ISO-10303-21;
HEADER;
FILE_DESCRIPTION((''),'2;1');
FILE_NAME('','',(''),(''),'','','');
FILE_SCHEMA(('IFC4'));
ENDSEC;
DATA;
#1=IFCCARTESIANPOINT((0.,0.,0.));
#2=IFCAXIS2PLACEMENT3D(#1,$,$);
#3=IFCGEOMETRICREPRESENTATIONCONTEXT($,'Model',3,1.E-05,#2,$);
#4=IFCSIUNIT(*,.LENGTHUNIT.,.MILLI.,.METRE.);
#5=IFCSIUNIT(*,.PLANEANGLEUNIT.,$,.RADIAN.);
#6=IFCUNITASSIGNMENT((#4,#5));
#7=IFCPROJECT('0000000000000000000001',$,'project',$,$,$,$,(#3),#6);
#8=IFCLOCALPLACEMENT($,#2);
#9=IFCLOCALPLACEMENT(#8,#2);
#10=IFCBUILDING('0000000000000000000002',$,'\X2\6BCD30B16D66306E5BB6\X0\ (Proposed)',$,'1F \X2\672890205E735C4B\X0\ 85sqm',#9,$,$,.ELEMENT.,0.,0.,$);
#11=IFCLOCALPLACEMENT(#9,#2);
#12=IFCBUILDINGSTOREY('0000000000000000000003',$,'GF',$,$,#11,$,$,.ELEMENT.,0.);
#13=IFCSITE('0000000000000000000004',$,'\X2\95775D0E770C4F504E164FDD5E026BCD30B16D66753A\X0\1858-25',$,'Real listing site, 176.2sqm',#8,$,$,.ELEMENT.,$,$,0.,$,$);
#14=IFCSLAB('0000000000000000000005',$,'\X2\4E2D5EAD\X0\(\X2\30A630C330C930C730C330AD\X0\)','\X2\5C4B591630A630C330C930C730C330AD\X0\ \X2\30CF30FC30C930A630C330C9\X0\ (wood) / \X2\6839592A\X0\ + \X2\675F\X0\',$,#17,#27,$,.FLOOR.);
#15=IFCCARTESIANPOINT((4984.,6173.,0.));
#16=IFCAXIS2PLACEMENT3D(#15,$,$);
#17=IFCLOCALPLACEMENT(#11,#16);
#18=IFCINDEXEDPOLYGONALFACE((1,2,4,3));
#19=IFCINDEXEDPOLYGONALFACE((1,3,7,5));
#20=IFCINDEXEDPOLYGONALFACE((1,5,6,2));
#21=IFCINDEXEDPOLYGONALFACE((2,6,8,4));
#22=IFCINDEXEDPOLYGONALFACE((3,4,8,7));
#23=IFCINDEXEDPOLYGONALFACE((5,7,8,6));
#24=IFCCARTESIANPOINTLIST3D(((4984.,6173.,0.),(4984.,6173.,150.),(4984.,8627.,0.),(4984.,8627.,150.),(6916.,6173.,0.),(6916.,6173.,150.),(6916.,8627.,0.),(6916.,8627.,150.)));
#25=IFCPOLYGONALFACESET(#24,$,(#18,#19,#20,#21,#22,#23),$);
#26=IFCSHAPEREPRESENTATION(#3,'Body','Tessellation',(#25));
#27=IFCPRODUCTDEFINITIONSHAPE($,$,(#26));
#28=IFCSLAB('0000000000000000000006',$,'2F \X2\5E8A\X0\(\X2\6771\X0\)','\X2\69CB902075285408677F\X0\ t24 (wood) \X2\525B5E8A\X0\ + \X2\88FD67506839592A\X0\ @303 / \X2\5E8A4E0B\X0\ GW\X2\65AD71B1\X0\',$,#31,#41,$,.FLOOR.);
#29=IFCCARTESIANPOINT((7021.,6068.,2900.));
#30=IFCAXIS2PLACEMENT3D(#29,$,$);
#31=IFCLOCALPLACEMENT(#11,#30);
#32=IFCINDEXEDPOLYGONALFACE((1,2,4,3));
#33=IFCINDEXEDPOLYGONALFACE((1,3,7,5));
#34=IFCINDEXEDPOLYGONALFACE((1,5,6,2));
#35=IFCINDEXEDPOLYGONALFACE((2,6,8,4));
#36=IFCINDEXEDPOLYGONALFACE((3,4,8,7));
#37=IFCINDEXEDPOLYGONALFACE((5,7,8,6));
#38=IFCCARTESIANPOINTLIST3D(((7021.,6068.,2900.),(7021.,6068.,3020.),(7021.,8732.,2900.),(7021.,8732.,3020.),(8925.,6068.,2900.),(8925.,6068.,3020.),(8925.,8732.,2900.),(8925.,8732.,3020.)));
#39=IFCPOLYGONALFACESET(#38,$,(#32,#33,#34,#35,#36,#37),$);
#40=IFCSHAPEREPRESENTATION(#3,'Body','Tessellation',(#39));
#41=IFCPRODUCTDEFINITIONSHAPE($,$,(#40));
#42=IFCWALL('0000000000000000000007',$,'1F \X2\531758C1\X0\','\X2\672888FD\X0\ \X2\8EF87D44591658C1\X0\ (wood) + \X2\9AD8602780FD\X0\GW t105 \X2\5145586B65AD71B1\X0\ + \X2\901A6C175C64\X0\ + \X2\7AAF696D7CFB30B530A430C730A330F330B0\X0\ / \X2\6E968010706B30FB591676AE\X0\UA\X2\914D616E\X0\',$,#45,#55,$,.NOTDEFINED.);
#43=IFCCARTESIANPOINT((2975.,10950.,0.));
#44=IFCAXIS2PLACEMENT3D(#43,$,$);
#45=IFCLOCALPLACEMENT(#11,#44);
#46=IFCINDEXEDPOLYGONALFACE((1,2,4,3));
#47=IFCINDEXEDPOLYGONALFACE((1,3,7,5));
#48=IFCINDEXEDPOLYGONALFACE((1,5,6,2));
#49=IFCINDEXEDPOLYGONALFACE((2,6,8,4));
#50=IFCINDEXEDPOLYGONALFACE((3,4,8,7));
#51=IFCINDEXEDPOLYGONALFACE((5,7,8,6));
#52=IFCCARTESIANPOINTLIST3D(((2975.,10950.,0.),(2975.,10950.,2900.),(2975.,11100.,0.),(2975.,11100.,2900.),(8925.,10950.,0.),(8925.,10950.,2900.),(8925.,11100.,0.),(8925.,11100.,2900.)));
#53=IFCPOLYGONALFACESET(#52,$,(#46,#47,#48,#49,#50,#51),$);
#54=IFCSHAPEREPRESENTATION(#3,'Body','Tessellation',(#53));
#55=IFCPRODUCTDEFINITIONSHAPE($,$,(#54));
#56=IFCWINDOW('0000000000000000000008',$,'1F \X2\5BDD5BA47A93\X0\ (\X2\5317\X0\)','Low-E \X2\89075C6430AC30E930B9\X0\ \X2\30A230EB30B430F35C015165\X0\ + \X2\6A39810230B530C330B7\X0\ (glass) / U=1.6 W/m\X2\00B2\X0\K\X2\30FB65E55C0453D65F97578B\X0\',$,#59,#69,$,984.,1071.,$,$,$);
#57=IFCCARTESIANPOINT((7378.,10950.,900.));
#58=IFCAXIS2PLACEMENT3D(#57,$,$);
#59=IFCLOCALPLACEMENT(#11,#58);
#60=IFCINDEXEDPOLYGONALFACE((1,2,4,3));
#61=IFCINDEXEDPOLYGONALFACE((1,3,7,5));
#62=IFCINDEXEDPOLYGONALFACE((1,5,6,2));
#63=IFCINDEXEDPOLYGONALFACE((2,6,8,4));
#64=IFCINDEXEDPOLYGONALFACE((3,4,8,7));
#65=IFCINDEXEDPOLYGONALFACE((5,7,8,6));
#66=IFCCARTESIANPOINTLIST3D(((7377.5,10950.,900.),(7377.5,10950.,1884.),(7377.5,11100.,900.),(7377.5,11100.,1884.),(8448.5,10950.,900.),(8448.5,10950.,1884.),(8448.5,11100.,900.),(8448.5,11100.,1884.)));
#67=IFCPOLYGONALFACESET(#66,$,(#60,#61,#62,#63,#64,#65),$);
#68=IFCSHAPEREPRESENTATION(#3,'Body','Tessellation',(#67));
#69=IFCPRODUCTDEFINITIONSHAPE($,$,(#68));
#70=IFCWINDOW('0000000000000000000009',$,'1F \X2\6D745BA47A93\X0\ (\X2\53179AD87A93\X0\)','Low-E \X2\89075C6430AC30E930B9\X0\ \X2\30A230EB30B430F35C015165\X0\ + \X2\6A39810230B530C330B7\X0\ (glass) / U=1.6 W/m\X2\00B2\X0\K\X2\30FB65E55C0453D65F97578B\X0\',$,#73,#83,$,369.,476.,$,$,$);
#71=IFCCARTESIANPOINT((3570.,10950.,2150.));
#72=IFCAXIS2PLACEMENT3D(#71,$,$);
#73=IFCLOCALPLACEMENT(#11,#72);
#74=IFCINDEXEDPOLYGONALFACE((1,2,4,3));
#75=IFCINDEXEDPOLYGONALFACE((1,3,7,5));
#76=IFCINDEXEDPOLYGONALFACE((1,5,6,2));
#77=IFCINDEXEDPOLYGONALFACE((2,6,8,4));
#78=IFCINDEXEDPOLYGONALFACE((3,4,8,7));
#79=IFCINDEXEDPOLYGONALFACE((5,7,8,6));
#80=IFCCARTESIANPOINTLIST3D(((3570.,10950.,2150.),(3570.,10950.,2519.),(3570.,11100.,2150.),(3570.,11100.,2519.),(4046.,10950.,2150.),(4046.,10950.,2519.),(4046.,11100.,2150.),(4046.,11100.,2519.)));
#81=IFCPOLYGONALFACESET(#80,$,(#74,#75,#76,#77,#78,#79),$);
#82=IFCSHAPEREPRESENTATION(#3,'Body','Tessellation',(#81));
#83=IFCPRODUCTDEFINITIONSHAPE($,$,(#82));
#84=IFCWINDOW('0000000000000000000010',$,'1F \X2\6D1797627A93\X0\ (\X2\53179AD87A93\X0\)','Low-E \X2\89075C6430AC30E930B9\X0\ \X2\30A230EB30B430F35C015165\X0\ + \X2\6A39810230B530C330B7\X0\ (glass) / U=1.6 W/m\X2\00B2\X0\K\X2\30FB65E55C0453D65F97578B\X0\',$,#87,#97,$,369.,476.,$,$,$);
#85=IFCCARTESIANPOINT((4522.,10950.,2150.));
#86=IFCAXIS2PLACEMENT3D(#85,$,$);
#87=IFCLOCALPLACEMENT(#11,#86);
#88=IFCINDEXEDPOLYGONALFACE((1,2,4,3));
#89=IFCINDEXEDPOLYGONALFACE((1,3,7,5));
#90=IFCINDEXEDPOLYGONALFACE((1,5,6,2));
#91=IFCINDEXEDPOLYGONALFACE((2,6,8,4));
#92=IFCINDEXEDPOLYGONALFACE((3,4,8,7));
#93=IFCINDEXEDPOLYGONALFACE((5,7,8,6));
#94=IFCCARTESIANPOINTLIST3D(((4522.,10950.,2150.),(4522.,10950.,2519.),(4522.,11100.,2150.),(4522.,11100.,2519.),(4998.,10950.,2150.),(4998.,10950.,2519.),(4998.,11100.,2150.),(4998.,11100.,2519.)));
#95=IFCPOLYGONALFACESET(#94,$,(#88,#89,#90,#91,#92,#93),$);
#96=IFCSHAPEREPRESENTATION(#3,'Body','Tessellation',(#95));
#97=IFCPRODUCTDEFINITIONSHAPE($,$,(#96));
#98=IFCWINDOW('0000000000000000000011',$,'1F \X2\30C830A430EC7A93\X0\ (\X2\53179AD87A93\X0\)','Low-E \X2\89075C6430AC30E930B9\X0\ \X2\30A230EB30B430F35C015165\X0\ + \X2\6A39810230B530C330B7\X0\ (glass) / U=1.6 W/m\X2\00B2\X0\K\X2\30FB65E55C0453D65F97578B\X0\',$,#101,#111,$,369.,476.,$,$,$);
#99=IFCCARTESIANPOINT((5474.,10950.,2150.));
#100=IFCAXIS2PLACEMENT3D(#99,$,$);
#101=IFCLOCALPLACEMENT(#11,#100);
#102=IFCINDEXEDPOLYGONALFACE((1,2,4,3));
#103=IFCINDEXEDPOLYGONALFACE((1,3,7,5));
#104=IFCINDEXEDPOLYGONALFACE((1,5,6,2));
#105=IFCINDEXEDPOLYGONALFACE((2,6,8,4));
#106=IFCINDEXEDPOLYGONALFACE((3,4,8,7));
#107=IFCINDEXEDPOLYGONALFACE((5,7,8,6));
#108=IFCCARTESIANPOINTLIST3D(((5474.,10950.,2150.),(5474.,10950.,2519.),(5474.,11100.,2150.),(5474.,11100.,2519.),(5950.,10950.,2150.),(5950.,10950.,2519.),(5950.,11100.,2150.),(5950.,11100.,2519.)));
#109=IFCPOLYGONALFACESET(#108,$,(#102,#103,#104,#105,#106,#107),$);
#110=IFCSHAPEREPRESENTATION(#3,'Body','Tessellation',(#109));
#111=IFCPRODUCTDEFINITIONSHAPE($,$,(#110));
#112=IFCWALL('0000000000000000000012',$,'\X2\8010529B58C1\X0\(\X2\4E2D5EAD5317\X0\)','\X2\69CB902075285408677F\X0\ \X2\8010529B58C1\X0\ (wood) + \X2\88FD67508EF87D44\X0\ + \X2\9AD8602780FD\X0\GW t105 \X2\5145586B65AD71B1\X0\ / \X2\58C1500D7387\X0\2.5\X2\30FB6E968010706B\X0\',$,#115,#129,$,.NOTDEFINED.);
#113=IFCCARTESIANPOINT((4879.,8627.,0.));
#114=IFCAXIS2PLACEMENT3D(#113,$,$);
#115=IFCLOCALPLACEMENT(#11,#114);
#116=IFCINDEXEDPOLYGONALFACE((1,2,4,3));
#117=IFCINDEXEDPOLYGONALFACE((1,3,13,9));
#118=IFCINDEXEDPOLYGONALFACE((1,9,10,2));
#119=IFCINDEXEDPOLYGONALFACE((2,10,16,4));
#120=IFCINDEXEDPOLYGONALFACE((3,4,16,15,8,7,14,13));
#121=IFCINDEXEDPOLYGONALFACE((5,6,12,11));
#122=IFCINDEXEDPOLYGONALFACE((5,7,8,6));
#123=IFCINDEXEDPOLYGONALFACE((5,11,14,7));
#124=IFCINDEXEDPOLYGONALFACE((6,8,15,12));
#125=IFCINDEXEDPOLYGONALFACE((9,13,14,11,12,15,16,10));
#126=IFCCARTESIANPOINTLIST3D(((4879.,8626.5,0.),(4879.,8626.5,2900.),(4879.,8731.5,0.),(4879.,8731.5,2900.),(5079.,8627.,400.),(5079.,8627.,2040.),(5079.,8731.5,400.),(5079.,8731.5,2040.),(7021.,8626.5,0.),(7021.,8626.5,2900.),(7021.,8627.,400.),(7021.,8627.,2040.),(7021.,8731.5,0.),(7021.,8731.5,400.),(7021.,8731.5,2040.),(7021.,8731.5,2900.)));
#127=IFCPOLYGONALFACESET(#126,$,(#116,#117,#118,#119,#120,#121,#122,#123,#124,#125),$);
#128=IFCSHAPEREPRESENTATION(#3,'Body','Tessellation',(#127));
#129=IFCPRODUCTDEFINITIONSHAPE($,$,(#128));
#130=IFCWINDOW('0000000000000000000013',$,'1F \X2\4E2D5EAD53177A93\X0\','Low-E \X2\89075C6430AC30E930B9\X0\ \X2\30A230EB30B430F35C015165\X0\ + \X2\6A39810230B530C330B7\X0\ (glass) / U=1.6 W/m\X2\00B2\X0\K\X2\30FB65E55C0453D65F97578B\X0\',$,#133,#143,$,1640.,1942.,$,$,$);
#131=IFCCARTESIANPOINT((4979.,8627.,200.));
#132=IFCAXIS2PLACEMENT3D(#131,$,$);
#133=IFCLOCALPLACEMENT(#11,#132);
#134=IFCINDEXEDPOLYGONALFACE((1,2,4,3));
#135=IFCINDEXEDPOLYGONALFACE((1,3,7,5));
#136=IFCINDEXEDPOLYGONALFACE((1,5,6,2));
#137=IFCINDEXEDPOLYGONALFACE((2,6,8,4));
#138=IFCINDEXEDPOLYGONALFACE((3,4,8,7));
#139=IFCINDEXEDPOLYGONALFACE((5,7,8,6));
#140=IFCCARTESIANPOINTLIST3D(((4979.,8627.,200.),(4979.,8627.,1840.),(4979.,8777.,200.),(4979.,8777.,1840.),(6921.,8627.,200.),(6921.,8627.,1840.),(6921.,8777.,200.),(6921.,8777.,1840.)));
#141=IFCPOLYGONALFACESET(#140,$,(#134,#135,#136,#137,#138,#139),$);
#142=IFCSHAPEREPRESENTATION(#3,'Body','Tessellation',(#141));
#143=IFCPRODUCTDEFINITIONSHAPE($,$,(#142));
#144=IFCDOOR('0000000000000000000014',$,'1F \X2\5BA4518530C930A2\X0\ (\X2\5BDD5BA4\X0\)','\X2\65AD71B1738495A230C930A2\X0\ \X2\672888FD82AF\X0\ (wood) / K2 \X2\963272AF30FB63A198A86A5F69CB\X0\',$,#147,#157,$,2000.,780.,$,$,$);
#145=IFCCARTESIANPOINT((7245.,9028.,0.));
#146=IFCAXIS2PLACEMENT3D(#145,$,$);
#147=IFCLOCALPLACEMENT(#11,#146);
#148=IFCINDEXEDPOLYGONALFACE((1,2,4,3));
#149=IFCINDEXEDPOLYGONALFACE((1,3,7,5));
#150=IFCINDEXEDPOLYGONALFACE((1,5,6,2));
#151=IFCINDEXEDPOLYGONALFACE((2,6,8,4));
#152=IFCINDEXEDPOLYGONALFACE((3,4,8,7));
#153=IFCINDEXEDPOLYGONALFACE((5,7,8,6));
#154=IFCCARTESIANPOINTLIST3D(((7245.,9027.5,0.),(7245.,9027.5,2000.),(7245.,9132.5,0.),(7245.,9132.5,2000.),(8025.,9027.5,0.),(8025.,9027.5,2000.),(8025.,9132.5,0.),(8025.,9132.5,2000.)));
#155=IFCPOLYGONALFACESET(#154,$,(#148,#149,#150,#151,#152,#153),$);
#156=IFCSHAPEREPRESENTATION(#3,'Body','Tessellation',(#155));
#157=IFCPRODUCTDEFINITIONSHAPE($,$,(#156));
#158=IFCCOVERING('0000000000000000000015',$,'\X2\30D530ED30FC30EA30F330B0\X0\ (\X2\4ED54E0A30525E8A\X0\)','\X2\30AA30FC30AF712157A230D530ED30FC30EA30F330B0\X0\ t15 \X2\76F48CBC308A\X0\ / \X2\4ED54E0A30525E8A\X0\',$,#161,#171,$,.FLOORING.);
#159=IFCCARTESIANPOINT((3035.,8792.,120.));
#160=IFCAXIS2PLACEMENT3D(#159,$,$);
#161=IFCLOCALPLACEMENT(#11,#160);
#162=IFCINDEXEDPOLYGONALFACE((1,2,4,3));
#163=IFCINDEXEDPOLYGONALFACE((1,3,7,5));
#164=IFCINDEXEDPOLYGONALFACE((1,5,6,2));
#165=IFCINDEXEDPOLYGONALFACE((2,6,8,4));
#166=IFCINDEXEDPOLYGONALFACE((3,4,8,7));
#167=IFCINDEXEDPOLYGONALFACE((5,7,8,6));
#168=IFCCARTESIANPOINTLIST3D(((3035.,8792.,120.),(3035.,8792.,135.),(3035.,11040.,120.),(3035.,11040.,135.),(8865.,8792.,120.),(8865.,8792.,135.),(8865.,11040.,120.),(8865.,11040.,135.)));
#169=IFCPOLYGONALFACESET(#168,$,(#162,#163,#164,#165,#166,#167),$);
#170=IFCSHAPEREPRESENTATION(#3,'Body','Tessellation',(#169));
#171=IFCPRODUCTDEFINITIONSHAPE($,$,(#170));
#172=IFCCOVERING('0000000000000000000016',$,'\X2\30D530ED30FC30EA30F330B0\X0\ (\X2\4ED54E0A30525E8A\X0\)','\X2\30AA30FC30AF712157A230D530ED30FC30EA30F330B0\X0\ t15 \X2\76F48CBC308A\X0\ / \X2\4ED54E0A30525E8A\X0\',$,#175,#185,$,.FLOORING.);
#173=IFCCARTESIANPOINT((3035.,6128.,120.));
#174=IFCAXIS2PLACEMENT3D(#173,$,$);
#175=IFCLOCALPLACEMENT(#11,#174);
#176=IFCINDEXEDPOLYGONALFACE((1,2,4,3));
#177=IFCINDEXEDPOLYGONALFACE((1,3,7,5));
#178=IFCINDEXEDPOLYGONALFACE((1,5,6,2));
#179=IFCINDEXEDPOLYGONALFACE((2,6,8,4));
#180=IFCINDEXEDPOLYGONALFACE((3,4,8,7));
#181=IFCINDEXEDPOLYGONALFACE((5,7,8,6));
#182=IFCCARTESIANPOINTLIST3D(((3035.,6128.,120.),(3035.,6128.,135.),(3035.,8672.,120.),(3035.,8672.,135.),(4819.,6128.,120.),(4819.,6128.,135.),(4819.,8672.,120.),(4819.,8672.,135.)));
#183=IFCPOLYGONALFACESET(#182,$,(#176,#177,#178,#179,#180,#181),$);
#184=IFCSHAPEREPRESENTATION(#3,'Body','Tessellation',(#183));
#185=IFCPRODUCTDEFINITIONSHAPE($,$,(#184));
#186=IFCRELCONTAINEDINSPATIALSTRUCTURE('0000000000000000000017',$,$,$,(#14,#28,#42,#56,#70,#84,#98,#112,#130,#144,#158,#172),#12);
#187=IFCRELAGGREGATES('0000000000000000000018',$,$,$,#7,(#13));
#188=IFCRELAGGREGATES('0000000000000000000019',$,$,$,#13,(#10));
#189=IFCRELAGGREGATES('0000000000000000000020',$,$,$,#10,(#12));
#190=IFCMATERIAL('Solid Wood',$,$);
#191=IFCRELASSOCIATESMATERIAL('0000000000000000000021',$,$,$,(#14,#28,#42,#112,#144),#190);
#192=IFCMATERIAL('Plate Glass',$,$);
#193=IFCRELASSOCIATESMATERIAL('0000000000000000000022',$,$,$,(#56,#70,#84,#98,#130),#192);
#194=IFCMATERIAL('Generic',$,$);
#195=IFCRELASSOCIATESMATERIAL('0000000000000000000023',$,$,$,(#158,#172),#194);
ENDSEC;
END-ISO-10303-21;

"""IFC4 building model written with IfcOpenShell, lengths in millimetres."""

from ifc_helpers import new_model, si_unit, frame, frame_2d, origin, place, context, project, spatial, rectangle, extrude, material, element, fill, save


model = new_model("IFC4")

# Units and contexts
model_context = context("Model", 3, precision=1e-05, world=origin())
ifc_project = project(units=[si_unit("LENGTHUNIT", "METRE", prefix="MILLI"), si_unit("PLANEANGLEUNIT", "RADIAN")], contexts=[model_context])

# Site, building, storey
site_placement = place(None, origin())
site = spatial("IfcSite", under=ifc_project, at=site_placement, Name="長崎県佐世保市母ケ浦町1858-25", ObjectType="Real listing site, 176.2sqm", CompositionType="ELEMENT", RefElevation=0.0)
building_placement = place(site_placement, origin())
building = spatial("IfcBuilding", under=site, at=building_placement, Name="母ケ浦の家 (Proposed)", ObjectType="1F 木造平屋 85sqm", CompositionType="ELEMENT", ElevationOfRefHeight=0.0, ElevationOfTerrain=0.0)
storey_placement = place(building_placement, origin())
storey = spatial("IfcBuildingStorey", under=building, at=storey_placement, Name="GF", CompositionType="ELEMENT", Elevation=0.0)

# Slabs
ifc_material_1 = material(Name="Solid Wood")
slab_1_placement = place(storey_placement, frame((4984.0, 6173.0, 0.0)))
element("IfcSlab", 1, at=slab_1_placement, inside=storey, material=ifc_material_1, Name="中庭(ウッドデッキ)", Description="屋外ウッドデッキ ハードウッド (wood) / 根太 + 束", PredefinedType="FLOOR", context=model_context, shape_type="SweptSolid", body=[
    extrude(rectangle(XDim=1932.0, YDim=2454.0, at=frame_2d((966.0, 1227.0))), frame((4984.0, 6173.0, 0.0)), (0.0, 0.0, 1.0), 150.0),
])
slab_2_placement = place(storey_placement, frame((7021.0, 6068.0, 2900.0)))
element("IfcSlab", 2, at=slab_2_placement, inside=storey, material=ifc_material_1, Name="2F 床(東)", Description="構造用合板 t24 (wood) 剛床 + 製材根太 @303 / 床下 GW断熱", PredefinedType="FLOOR", context=model_context, shape_type="SweptSolid", body=[
    extrude(rectangle(XDim=1904.0, YDim=2664.0, at=frame_2d((952.0, 1332.0))), frame((7021.0, 6068.0, 2900.0)), (0.0, 0.0, 1.0), 120.0),
])

# Wall, openings, windows
wall_1_placement = place(storey_placement, frame((2975.0, 10950.0, 0.0)))
wall_1 = element("IfcWall", 3, at=wall_1_placement, inside=storey, material=ifc_material_1, Name="1F 北壁", Description="木製 軸組外壁 (wood) + 高性能GW t105 充填断熱 + 通気層 + 窯業系サイディング / 準耐火・外皮UA配慮", PredefinedType="NOTDEFINED", context=model_context, shape_type="SweptSolid", body=[
    extrude(rectangle(XDim=5950.0, YDim=150.0, at=frame_2d((2975.0, 75.0))), frame((2975.0, 10950.0, 0.0)), (0.0, 0.0, 1.0), 2900.0),
])
opening_1_placement = place(storey_placement, frame((7378.0, 10950.0, 900.0)))
opening_1 = element("IfcOpeningElement", 4, at=opening_1_placement, cuts=wall_1, PredefinedType="NOTDEFINED", context=model_context, shape_type="SweptSolid", body=[
    extrude(rectangle(XDim=1071.0, YDim=150.0, at=frame_2d((535.0, 75.0))), frame((7378.0, 10950.0, 900.0)), (0.0, 0.0, 1.0), 984.0),
])
opening_2_placement = place(storey_placement, frame((3570.0, 10950.0, 2150.0)))
opening_2 = element("IfcOpeningElement", 5, at=opening_2_placement, cuts=wall_1, PredefinedType="NOTDEFINED", context=model_context, shape_type="SweptSolid", body=[
    extrude(rectangle(XDim=476.0, YDim=150.0, at=frame_2d((238.0, 75.0))), frame((3570.0, 10950.0, 2150.0)), (0.0, 0.0, 1.0), 369.0),
])
opening_3_placement = place(storey_placement, frame((4522.0, 10950.0, 2150.0)))
opening_3 = element("IfcOpeningElement", 6, at=opening_3_placement, cuts=wall_1, PredefinedType="NOTDEFINED", context=model_context, shape_type="SweptSolid", body=[
    extrude(rectangle(XDim=476.0, YDim=150.0, at=frame_2d((238.0, 75.0))), frame((4522.0, 10950.0, 2150.0)), (0.0, 0.0, 1.0), 369.0),
])
opening_4_placement = place(storey_placement, frame((5474.0, 10950.0, 2150.0)))
opening_4 = element("IfcOpeningElement", 7, at=opening_4_placement, cuts=wall_1, PredefinedType="NOTDEFINED", context=model_context, shape_type="SweptSolid", body=[
    extrude(rectangle(XDim=476.0, YDim=150.0, at=frame_2d((238.0, 75.0))), frame((5474.0, 10950.0, 2150.0)), (0.0, 0.0, 1.0), 369.0),
])
ifc_material_2 = material(Name="Plate Glass")
window_1_placement = place(storey_placement, frame((7378.0, 10950.0, 900.0)))
window_1 = element("IfcWindow", 8, at=window_1_placement, inside=storey, material=ifc_material_2, Name="1F 寝室窓 (北)", Description="Low-E 複層ガラス アルゴン封入 + 樹脂サッシ (glass) / U=1.6 W/m²K・日射取得型", OverallHeight=984.0, OverallWidth=1071.0, context=model_context, shape_type="SweptSolid", body=[
    extrude(rectangle(XDim=1071.0, YDim=150.0, at=frame_2d((535.0, 75.0))), frame((7378.0, 10950.0, 900.0)), (0.0, 0.0, 1.0), 984.0),
])
fill(opening_1, window_1)
window_2_placement = place(storey_placement, frame((3570.0, 10950.0, 2150.0)))
window_2 = element("IfcWindow", 9, at=window_2_placement, inside=storey, material=ifc_material_2, Name="1F 浴室窓 (北高窓)", Description="Low-E 複層ガラス アルゴン封入 + 樹脂サッシ (glass) / U=1.6 W/m²K・日射取得型", OverallHeight=369.0, OverallWidth=476.0, context=model_context, shape_type="SweptSolid", body=[
    extrude(rectangle(XDim=476.0, YDim=150.0, at=frame_2d((238.0, 75.0))), frame((3570.0, 10950.0, 2150.0)), (0.0, 0.0, 1.0), 369.0),
])
fill(opening_2, window_2)
window_3_placement = place(storey_placement, frame((4522.0, 10950.0, 2150.0)))
window_3 = element("IfcWindow", 10, at=window_3_placement, inside=storey, material=ifc_material_2, Name="1F 洗面窓 (北高窓)", Description="Low-E 複層ガラス アルゴン封入 + 樹脂サッシ (glass) / U=1.6 W/m²K・日射取得型", OverallHeight=369.0, OverallWidth=476.0, context=model_context, shape_type="SweptSolid", body=[
    extrude(rectangle(XDim=476.0, YDim=150.0, at=frame_2d((238.0, 75.0))), frame((4522.0, 10950.0, 2150.0)), (0.0, 0.0, 1.0), 369.0),
])
fill(opening_3, window_3)
window_4_placement = place(storey_placement, frame((5474.0, 10950.0, 2150.0)))
window_4 = element("IfcWindow", 11, at=window_4_placement, inside=storey, material=ifc_material_2, Name="1F トイレ窓 (北高窓)", Description="Low-E 複層ガラス アルゴン封入 + 樹脂サッシ (glass) / U=1.6 W/m²K・日射取得型", OverallHeight=369.0, OverallWidth=476.0, context=model_context, shape_type="SweptSolid", body=[
    extrude(rectangle(XDim=476.0, YDim=150.0, at=frame_2d((238.0, 75.0))), frame((5474.0, 10950.0, 2150.0)), (0.0, 0.0, 1.0), 369.0),
])
fill(opening_4, window_4)

# Wall, opening, window
wall_2_placement = place(storey_placement, frame((4879.0, 8627.0, 0.0)))
wall_2 = element("IfcWall", 12, at=wall_2_placement, inside=storey, material=ifc_material_1, Name="耐力壁(中庭北)", Description="構造用合板 耐力壁 (wood) + 製材軸組 + 高性能GW t105 充填断熱 / 壁倍率2.5・準耐火", PredefinedType="NOTDEFINED", context=model_context, shape_type="SweptSolid", body=[
    extrude(rectangle(XDim=2142.0, YDim=105.0, at=frame_2d((1071.0, 52.0))), frame((4879.0, 8627.0, 0.0)), (0.0, 0.0, 1.0), 2900.0),
])
opening_5_placement = place(storey_placement, frame((4979.0, 8627.0, 200.0)))
opening_5 = element("IfcOpeningElement", 13, at=opening_5_placement, cuts=wall_2, PredefinedType="NOTDEFINED", context=model_context, shape_type="SweptSolid", body=[
    extrude(rectangle(XDim=1942.0, YDim=150.0, at=frame_2d((971.0, 75.0))), frame((4979.0, 8627.0, 200.0)), (0.0, 0.0, 1.0), 1640.0),
])
window_5_placement = place(storey_placement, frame((4979.0, 8627.0, 200.0)))
window_5 = element("IfcWindow", 14, at=window_5_placement, inside=storey, material=ifc_material_2, Name="1F 中庭北窓", Description="Low-E 複層ガラス アルゴン封入 + 樹脂サッシ (glass) / U=1.6 W/m²K・日射取得型", OverallHeight=1640.0, OverallWidth=1942.0, context=model_context, shape_type="SweptSolid", body=[
    extrude(rectangle(XDim=1942.0, YDim=150.0, at=frame_2d((971.0, 75.0))), frame((4979.0, 8627.0, 200.0)), (0.0, 0.0, 1.0), 1640.0),
])
fill(opening_5, window_5)

# Door
door_1_placement = place(storey_placement, frame((7245.0, 9028.0, 0.0)))
element("IfcDoor", 15, at=door_1_placement, inside=storey, material=ifc_material_1, Name="1F 室内ドア (寝室)", Description="断熱玄関ドア 木製芯 (wood) / K2 防犯・採風機構", OverallHeight=2000.0, OverallWidth=780.0, context=model_context, shape_type="SweptSolid", body=[
    extrude(rectangle(XDim=780.0, YDim=105.0, at=frame_2d((390.0, 52.0))), frame((7245.0, 9028.0, 0.0)), (0.0, 0.0, 1.0), 2000.0),
])

# Coverings
ifc_material_3 = material(Name="Generic")
covering_1_placement = place(storey_placement, frame((3035.0, 8792.0, 120.0)))
element("IfcCovering", 16, at=covering_1_placement, inside=storey, material=ifc_material_3, Name="フローリング (仕上げ床)", Description="オーク無垢フローリング t15 直貼り / 仕上げ床", PredefinedType="FLOORING", context=model_context, shape_type="SweptSolid", body=[
    extrude(rectangle(XDim=5830.0, YDim=2248.0, at=frame_2d((2915.0, 1124.0))), frame((3035.0, 8792.0, 120.0)), (0.0, 0.0, 1.0), 15.0),
])
covering_2_placement = place(storey_placement, frame((3035.0, 6128.0, 120.0)))
element("IfcCovering", 17, at=covering_2_placement, inside=storey, material=ifc_material_3, Name="フローリング (仕上げ床)", Description="オーク無垢フローリング t15 直貼り / 仕上げ床", PredefinedType="FLOORING", context=model_context, shape_type="SweptSolid", body=[
    extrude(rectangle(XDim=1784.0, YDim=2544.0, at=frame_2d((892.0, 1272.0))), frame((3035.0, 6128.0, 120.0)), (0.0, 0.0, 1.0), 15.0),
])

save(model, "model.ifc")
